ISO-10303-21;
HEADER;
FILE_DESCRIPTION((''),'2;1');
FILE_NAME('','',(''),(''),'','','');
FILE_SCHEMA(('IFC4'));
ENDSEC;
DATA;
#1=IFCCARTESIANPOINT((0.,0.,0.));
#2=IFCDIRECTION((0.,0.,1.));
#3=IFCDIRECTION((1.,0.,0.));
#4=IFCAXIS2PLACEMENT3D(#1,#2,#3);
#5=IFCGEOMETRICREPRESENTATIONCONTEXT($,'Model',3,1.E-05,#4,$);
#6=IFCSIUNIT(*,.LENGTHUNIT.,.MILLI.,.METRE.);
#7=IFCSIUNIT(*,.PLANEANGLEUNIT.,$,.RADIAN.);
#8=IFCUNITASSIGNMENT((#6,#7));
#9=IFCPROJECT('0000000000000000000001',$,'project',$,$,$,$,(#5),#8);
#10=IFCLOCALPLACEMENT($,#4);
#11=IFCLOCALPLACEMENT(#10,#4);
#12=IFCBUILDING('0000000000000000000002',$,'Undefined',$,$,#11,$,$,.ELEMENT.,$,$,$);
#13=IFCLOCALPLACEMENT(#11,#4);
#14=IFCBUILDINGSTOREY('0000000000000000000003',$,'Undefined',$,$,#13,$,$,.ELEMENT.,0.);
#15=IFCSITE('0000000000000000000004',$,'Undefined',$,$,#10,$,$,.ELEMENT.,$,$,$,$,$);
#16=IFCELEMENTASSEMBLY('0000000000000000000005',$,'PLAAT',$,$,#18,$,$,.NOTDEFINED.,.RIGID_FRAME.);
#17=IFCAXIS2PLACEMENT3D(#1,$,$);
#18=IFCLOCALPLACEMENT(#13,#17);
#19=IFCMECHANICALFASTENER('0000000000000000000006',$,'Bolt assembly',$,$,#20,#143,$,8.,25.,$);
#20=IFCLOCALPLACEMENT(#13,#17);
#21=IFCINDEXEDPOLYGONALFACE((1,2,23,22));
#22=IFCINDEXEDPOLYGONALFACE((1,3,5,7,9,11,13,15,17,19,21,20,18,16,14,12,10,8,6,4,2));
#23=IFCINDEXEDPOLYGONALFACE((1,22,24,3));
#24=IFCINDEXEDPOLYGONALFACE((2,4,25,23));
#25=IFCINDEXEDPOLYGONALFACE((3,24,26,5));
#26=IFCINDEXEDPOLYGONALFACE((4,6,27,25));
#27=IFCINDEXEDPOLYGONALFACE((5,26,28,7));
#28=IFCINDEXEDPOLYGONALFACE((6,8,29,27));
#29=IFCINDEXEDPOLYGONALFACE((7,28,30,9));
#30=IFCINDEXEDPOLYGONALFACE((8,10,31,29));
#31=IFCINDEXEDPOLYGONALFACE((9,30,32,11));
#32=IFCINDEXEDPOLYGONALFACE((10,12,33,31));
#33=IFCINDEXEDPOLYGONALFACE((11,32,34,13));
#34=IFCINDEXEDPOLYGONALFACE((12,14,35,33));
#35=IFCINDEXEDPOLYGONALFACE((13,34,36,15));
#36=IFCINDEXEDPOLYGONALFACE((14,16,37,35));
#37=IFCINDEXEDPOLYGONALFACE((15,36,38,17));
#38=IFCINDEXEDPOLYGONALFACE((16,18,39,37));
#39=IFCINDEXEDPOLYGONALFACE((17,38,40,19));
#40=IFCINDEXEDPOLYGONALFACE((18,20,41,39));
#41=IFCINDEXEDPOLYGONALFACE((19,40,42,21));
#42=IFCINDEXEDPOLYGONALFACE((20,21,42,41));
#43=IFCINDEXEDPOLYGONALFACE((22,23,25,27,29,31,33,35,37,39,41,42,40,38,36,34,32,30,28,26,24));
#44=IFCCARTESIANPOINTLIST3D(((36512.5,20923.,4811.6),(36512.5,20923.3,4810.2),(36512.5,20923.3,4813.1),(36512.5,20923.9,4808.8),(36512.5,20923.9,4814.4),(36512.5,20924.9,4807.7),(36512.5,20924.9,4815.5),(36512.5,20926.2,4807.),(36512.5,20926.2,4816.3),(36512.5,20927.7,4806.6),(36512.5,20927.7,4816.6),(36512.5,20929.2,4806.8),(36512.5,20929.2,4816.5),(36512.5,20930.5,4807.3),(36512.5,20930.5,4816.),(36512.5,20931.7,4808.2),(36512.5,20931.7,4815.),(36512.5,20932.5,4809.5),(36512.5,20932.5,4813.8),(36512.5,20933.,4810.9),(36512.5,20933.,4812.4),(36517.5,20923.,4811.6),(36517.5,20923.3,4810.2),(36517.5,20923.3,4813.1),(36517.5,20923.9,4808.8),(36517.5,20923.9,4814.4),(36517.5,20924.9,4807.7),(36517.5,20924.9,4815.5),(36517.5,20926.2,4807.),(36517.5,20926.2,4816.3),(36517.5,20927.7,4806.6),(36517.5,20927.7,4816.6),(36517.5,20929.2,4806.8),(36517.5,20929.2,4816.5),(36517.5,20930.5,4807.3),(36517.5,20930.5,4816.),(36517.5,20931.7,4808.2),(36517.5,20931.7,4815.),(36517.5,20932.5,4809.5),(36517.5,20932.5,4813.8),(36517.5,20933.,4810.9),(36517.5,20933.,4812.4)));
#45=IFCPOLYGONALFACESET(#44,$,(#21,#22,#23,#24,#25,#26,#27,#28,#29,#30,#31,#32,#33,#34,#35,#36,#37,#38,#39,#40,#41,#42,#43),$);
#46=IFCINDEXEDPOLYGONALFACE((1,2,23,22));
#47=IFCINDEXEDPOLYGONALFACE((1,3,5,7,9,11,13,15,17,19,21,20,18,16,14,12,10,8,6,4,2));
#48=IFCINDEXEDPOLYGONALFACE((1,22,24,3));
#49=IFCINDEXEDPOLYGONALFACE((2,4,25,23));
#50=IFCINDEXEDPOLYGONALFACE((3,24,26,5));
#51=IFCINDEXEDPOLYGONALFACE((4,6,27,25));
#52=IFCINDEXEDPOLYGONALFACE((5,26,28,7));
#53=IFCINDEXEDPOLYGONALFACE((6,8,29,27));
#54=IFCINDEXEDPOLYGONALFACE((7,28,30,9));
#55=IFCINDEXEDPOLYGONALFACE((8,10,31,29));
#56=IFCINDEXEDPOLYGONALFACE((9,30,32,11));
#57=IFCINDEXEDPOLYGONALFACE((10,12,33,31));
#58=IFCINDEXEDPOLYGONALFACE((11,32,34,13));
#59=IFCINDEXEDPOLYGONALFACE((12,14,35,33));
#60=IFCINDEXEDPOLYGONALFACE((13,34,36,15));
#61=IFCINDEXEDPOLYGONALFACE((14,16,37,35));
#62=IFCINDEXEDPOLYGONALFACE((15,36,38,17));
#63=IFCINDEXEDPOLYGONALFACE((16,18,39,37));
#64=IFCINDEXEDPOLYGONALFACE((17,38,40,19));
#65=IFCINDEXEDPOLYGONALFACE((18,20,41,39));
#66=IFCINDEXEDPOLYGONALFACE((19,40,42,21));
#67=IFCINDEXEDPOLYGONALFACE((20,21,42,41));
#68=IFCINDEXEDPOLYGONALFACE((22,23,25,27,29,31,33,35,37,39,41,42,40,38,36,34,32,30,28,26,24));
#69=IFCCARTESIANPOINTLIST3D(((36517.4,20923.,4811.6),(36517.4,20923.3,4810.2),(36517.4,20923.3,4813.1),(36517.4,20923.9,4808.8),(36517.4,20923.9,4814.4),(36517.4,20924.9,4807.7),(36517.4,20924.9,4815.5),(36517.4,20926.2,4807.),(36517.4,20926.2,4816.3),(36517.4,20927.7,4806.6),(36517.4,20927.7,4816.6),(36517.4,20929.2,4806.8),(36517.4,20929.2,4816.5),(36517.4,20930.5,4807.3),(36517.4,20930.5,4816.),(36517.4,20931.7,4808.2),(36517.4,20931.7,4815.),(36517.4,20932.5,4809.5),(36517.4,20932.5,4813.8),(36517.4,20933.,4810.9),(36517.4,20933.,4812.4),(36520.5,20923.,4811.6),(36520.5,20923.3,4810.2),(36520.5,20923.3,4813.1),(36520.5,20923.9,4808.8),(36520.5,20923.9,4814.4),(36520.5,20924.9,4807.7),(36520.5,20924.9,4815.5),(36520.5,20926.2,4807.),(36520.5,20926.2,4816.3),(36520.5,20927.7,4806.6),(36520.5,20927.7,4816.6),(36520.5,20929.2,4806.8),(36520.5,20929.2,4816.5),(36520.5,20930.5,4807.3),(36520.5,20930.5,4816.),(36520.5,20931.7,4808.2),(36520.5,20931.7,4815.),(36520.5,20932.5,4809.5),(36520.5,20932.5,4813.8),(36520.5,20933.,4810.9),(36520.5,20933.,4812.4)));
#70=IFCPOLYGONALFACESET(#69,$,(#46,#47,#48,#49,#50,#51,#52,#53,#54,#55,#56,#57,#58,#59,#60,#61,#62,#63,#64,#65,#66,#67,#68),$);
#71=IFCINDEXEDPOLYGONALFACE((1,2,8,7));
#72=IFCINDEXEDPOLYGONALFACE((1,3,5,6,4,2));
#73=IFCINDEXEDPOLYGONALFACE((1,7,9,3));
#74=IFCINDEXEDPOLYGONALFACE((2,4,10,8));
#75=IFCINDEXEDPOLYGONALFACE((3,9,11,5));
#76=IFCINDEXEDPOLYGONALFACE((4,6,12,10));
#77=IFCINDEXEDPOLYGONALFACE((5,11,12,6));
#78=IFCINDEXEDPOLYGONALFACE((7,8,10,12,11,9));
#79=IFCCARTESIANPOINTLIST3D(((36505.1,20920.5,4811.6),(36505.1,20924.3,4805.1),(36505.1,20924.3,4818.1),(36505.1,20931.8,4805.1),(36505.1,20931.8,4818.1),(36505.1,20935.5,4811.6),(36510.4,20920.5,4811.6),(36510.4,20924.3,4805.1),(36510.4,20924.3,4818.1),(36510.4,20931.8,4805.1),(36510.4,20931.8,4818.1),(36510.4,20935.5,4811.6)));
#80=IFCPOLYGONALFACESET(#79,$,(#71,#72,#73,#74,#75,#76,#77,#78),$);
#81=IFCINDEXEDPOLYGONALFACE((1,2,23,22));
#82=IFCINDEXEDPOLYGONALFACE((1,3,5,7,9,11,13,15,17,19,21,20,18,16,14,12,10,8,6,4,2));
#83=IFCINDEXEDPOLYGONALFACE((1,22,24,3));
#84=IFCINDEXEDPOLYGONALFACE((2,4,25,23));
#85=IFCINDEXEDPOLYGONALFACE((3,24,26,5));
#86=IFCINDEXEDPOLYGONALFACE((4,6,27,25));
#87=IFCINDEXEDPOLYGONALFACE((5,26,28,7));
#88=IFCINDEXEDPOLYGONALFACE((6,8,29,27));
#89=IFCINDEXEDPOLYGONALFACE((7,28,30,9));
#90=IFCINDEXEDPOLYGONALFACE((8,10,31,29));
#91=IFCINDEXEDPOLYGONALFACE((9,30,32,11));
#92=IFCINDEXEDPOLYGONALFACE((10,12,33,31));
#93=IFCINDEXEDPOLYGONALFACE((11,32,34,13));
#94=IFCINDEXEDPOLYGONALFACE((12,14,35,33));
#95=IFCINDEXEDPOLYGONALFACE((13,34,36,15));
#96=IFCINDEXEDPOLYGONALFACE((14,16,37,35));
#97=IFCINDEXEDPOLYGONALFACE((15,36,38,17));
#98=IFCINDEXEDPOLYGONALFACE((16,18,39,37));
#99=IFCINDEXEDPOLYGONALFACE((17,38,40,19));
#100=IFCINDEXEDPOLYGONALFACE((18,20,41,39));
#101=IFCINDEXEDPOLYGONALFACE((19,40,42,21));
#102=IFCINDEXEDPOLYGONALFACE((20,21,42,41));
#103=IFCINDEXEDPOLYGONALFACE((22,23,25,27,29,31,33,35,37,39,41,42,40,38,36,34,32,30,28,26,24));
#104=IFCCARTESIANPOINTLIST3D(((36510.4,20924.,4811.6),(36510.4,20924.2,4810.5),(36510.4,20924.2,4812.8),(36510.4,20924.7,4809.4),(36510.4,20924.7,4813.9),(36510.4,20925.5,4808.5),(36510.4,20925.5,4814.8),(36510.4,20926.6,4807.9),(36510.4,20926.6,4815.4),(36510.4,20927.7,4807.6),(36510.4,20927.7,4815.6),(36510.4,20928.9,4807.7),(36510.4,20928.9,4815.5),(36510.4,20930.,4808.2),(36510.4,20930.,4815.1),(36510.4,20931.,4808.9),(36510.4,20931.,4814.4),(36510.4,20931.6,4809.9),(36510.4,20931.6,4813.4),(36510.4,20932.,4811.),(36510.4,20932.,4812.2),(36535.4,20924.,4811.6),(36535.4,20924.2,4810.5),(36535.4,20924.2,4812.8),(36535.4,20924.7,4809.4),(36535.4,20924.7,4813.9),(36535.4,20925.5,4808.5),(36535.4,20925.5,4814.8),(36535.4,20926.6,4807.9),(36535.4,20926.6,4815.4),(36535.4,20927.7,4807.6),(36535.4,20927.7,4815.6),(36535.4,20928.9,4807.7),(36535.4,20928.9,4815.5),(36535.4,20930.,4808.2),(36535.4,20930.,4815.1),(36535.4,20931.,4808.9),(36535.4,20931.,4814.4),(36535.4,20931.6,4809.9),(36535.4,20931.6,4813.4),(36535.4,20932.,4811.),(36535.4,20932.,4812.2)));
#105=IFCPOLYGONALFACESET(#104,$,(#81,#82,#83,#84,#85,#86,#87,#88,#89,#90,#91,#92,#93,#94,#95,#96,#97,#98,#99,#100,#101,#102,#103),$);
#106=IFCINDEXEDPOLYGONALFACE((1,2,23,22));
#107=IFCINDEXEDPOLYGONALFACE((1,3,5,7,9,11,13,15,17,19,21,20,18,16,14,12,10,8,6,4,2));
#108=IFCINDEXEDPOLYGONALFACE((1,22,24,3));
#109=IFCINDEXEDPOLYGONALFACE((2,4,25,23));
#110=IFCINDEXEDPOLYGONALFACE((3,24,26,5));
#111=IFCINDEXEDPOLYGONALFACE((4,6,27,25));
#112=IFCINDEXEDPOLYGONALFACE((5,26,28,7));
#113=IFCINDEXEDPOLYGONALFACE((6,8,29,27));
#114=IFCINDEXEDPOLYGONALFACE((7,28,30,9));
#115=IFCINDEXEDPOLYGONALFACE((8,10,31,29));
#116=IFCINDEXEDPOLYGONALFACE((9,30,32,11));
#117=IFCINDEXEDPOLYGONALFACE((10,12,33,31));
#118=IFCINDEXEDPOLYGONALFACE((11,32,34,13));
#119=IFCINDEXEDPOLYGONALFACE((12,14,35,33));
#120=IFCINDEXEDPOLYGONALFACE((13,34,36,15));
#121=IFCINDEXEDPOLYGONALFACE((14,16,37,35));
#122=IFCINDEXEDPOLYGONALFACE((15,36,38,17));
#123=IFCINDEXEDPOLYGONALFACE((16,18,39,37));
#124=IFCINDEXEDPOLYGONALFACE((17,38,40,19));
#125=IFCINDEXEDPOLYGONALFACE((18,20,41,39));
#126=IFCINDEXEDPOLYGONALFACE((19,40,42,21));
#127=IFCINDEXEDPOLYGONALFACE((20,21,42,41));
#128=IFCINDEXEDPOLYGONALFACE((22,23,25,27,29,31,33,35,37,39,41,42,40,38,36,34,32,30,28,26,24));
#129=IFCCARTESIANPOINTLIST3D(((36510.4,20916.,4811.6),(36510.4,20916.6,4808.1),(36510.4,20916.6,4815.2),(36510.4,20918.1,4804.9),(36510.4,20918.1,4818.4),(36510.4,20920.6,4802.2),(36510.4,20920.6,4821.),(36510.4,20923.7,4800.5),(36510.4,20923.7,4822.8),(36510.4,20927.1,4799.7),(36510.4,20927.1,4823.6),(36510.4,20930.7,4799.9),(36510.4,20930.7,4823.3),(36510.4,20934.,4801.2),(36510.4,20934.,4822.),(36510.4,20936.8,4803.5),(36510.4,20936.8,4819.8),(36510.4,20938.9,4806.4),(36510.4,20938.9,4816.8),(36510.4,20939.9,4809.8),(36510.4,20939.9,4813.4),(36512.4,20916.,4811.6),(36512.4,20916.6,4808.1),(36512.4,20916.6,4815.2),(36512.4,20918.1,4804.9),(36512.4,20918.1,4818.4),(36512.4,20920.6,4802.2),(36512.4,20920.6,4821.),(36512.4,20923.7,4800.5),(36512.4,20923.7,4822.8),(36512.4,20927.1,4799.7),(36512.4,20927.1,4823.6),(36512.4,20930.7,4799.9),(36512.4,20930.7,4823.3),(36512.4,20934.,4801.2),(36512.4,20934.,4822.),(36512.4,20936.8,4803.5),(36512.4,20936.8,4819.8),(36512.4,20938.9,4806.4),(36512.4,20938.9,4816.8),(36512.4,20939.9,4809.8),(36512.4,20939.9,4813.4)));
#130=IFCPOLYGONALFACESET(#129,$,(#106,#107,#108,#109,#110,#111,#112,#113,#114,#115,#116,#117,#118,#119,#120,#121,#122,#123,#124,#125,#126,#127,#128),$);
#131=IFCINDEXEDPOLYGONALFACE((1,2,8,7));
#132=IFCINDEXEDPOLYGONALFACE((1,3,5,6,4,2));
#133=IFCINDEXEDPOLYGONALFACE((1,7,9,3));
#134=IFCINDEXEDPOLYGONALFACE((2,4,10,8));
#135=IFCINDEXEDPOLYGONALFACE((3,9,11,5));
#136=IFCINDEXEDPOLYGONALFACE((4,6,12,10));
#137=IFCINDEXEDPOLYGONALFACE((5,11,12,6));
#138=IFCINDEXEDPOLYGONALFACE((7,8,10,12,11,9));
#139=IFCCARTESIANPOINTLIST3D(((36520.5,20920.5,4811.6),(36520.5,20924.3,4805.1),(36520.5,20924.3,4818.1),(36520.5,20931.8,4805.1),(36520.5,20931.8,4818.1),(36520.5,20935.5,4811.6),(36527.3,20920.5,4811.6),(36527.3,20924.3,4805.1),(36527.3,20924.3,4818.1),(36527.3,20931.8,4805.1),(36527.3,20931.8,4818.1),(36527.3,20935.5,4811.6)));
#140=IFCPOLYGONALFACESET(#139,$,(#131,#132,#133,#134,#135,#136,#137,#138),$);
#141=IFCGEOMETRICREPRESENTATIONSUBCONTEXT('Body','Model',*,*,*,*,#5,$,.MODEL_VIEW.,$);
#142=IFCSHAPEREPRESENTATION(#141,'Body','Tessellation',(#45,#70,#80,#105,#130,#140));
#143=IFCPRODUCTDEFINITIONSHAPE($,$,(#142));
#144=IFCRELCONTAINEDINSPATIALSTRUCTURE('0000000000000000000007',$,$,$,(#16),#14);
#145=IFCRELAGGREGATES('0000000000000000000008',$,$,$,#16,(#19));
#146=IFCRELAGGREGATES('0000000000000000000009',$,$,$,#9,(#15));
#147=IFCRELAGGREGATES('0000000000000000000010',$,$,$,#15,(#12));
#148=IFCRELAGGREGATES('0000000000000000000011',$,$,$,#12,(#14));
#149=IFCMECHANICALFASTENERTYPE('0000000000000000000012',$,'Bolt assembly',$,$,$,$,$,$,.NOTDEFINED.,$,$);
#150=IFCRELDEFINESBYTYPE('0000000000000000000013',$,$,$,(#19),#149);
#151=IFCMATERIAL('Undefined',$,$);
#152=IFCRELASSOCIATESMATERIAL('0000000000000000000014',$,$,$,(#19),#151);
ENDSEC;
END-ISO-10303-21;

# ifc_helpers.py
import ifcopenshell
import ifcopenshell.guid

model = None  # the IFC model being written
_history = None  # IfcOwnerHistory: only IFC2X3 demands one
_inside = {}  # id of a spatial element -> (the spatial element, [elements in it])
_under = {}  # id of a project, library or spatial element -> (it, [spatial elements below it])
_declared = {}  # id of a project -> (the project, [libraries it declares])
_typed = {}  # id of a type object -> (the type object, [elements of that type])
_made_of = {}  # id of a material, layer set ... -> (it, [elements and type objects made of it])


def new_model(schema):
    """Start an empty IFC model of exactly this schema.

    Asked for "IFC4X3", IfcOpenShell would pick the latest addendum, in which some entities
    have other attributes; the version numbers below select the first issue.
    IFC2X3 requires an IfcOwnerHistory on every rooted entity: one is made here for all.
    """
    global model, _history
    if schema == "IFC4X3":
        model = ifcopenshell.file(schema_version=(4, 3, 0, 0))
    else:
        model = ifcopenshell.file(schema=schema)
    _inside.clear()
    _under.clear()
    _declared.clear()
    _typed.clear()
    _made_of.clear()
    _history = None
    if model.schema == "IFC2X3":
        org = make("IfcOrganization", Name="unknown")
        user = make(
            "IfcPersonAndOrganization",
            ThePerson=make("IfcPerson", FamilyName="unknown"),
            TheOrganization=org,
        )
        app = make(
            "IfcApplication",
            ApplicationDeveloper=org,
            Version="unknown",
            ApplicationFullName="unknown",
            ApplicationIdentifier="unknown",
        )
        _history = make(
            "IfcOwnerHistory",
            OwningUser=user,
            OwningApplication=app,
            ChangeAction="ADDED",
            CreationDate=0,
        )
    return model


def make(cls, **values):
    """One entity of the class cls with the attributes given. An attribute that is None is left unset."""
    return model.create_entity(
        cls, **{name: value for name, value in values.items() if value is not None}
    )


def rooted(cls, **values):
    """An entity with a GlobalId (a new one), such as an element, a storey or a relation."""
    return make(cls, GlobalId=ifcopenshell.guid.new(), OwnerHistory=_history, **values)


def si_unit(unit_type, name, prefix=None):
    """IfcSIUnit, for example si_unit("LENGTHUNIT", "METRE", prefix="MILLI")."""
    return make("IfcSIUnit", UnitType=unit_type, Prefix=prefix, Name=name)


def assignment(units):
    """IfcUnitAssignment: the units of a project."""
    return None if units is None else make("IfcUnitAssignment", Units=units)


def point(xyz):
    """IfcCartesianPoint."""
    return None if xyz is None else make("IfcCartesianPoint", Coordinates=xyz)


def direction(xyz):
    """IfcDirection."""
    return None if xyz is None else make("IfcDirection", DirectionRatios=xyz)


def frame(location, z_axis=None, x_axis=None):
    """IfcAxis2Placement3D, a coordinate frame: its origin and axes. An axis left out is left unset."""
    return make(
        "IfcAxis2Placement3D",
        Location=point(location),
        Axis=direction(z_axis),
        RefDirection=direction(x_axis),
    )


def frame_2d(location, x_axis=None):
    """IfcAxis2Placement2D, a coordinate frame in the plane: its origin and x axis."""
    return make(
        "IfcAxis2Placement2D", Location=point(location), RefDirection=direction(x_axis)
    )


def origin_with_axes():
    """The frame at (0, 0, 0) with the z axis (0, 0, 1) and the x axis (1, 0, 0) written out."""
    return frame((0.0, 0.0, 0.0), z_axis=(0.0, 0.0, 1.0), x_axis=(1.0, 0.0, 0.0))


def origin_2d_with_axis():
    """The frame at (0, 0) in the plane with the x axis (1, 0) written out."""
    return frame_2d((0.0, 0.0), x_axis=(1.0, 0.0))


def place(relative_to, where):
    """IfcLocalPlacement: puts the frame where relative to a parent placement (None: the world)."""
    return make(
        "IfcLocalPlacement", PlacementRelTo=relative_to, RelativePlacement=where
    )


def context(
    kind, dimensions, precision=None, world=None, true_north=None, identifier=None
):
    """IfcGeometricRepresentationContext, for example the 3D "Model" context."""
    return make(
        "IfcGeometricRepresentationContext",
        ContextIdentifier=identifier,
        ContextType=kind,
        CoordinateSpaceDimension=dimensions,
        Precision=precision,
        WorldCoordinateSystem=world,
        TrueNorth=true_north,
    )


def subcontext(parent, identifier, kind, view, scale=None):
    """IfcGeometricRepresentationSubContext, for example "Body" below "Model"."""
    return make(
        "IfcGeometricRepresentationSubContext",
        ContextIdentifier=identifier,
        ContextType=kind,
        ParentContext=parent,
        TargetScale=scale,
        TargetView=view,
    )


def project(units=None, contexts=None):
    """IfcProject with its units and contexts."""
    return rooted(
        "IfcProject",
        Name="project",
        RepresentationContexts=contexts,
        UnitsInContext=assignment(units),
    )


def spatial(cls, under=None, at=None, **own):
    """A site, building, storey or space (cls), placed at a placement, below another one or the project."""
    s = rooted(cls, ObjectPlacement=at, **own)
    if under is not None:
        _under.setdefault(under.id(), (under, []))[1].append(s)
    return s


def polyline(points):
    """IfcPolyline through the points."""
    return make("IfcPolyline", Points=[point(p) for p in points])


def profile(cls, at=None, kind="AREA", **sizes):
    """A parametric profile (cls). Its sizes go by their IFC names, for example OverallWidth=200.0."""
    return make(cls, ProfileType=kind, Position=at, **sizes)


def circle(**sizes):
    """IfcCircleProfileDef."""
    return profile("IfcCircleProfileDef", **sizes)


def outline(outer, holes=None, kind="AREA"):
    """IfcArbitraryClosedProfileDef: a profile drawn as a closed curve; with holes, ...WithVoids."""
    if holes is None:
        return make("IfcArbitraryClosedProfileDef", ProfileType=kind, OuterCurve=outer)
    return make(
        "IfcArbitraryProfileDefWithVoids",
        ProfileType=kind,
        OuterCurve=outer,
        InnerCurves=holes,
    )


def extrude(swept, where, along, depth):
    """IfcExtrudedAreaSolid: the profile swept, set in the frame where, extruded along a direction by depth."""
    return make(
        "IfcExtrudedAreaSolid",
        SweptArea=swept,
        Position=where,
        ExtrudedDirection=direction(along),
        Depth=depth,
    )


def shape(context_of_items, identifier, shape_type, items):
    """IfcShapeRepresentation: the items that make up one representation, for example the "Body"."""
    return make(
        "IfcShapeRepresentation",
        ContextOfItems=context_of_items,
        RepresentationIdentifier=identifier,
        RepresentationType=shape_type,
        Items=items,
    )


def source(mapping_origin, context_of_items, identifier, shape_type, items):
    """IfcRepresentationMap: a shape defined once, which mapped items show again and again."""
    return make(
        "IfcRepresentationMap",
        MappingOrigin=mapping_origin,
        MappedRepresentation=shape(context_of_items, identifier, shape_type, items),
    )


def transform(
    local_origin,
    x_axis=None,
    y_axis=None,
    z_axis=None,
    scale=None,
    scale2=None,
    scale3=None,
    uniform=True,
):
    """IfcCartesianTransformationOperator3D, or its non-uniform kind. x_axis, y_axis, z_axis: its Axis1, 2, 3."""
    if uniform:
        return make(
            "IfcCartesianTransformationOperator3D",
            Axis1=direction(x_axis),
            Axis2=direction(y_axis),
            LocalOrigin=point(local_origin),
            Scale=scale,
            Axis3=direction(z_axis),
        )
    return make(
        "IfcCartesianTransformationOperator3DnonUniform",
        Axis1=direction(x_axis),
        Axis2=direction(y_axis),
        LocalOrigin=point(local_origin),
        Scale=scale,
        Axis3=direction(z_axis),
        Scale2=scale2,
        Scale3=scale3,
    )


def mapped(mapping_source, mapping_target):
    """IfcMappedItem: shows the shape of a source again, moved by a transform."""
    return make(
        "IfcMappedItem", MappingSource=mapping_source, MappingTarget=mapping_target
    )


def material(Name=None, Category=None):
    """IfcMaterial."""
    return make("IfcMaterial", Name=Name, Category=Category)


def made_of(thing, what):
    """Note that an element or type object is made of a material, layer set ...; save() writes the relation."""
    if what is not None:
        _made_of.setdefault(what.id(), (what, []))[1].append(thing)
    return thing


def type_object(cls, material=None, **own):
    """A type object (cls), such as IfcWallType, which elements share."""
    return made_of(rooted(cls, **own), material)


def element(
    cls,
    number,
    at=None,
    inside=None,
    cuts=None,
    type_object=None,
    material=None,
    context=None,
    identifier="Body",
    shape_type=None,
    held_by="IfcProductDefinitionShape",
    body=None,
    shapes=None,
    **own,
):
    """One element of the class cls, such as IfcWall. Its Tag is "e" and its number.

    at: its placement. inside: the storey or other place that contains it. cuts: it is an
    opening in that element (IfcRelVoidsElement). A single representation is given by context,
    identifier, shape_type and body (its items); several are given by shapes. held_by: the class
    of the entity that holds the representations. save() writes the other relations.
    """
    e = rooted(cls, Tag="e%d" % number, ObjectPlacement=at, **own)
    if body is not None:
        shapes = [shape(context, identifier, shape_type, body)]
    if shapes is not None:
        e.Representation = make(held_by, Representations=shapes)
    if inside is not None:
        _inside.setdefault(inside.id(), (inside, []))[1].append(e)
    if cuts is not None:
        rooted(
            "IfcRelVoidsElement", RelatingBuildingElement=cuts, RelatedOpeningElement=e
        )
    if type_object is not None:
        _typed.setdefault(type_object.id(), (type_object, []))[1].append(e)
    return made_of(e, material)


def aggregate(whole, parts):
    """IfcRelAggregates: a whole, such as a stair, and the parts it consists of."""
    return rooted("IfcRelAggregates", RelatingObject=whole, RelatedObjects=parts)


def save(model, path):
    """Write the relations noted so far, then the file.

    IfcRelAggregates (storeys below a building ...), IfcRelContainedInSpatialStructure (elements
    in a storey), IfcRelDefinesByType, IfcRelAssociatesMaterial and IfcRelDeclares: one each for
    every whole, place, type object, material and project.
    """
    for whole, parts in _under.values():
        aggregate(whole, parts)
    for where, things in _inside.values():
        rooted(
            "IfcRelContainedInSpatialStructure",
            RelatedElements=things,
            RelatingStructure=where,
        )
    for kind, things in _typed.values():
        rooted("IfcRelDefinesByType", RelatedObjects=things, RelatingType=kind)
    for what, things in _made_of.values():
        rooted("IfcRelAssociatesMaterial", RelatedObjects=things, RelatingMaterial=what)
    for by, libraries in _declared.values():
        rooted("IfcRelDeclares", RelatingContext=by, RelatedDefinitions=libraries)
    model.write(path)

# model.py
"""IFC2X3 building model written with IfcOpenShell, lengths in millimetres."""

from ifc_helpers import new_model, si_unit, frame, origin_with_axes, origin_2d_with_axis, place, context, subcontext, project, spatial, polyline, circle, outline, extrude, source, transform, mapped, material, type_object, element, aggregate, save


model = new_model("IFC2X3")

# Units and contexts
model_context = context("Model", 3, precision=1e-05, world=origin_with_axes())
body_context = subcontext(model_context, "Body", "Model", "MODEL_VIEW")
ifc_project = project(units=[si_unit("LENGTHUNIT", "METRE", prefix="MILLI"), si_unit("PLANEANGLEUNIT", "RADIAN")], contexts=[model_context])

# Site, building, storey
site_placement = place(None, origin_with_axes())
site = spatial("IfcSite", under=ifc_project, at=site_placement, Name="Undefined", CompositionType="ELEMENT")
building_placement = place(site_placement, origin_with_axes())
building = spatial("IfcBuilding", under=site, at=building_placement, Name="Undefined", CompositionType="ELEMENT")
storey_placement = place(building_placement, origin_with_axes())
storey = spatial("IfcBuildingStorey", under=building, at=storey_placement, Name="Undefined", CompositionType="ELEMENT", Elevation=0.0)

# Element assembly
ifc_material_1 = material(Name="Undefined")
mechanical_fastener_type = type_object("IfcMechanicalFastenerType", Name="Bolt assembly")
assembly_1_placement = place(storey_placement, origin_with_axes())
assembly_1 = element("IfcElementAssembly", 1, at=assembly_1_placement, inside=storey, Name="PLAAT", AssemblyPlace="NOTDEFINED", PredefinedType="RIGID_FRAME")
shared_shape_1 = source(origin_with_axes(), body_context, "Body", "SweptSolid", [
    extrude(circle(Radius=5.0, at=origin_2d_with_axis()), frame((0.0, 7.5, 0.0), z_axis=(0.0, 1.0, 0.0), x_axis=(1.0, 0.0, 0.0)), (0.0, 0.0, 1.0), 5.0),
    extrude(circle(Radius=5.0, at=origin_2d_with_axis()), frame((0.0, 12.4, 0.0), z_axis=(0.0, 1.0, 0.0), x_axis=(1.0, 0.0, 0.0)), (0.0, 0.0, 1.0), 3.1),
    extrude(outline(polyline([(7.5, 0.0), (3.8, 6.5), (-3.8, 6.5), (-7.5, 0.0), (-3.8, -6.5), (3.8, -6.5), (7.5, 0.0)])), frame((0.0, 0.1, 0.0), z_axis=(0.0, 1.0, 0.0), x_axis=(1.0, 0.0, 0.0)), (0.0, 0.0, 1.0), 5.3),
    extrude(circle(Radius=4.0, at=origin_2d_with_axis()), frame((0.0, 5.4, 0.0), z_axis=(0.0, 1.0, 0.0), x_axis=(1.0, 0.0, 0.0)), (0.0, 0.0, 1.0), 25.0),
    extrude(circle(Radius=12.0, at=origin_2d_with_axis()), frame((0.0, 5.4, 0.0), z_axis=(0.0, 1.0, 0.0), x_axis=(1.0, 0.0, 0.0)), (0.0, 0.0, 1.0), 2.0),
    extrude(outline(polyline([(7.5, 0.0), (3.8, 6.5), (-3.8, 6.5), (-7.5, 0.0), (-3.8, -6.5), (3.8, -6.5), (7.5, 0.0)])), frame((0.0, 15.5, 0.0), z_axis=(0.0, 1.0, 0.0), x_axis=(1.0, 0.0, 0.0)), (0.0, 0.0, 1.0), 6.8),
])

# Mechanical fastener
mechanical_fastener_1_placement = place(assembly_1_placement, frame((36505.0, 20928.0, 4811.6), z_axis=(0.0, 0.000002, 1.0), x_axis=(0.0, -1.0, 0.000002)))
mechanical_fastener_1 = element("IfcMechanicalFastener", 2, at=mechanical_fastener_1_placement, type_object=mechanical_fastener_type, material=ifc_material_1, Name="Bolt assembly", NominalDiameter=8.0, NominalLength=25.0, context=body_context, shape_type="MappedRepresentation", body=[
    mapped(shared_shape_1, transform((0.0, 0.0, 0.0))),
])
aggregate(assembly_1, [mechanical_fastener_1])

save(model, "model.ifc")
